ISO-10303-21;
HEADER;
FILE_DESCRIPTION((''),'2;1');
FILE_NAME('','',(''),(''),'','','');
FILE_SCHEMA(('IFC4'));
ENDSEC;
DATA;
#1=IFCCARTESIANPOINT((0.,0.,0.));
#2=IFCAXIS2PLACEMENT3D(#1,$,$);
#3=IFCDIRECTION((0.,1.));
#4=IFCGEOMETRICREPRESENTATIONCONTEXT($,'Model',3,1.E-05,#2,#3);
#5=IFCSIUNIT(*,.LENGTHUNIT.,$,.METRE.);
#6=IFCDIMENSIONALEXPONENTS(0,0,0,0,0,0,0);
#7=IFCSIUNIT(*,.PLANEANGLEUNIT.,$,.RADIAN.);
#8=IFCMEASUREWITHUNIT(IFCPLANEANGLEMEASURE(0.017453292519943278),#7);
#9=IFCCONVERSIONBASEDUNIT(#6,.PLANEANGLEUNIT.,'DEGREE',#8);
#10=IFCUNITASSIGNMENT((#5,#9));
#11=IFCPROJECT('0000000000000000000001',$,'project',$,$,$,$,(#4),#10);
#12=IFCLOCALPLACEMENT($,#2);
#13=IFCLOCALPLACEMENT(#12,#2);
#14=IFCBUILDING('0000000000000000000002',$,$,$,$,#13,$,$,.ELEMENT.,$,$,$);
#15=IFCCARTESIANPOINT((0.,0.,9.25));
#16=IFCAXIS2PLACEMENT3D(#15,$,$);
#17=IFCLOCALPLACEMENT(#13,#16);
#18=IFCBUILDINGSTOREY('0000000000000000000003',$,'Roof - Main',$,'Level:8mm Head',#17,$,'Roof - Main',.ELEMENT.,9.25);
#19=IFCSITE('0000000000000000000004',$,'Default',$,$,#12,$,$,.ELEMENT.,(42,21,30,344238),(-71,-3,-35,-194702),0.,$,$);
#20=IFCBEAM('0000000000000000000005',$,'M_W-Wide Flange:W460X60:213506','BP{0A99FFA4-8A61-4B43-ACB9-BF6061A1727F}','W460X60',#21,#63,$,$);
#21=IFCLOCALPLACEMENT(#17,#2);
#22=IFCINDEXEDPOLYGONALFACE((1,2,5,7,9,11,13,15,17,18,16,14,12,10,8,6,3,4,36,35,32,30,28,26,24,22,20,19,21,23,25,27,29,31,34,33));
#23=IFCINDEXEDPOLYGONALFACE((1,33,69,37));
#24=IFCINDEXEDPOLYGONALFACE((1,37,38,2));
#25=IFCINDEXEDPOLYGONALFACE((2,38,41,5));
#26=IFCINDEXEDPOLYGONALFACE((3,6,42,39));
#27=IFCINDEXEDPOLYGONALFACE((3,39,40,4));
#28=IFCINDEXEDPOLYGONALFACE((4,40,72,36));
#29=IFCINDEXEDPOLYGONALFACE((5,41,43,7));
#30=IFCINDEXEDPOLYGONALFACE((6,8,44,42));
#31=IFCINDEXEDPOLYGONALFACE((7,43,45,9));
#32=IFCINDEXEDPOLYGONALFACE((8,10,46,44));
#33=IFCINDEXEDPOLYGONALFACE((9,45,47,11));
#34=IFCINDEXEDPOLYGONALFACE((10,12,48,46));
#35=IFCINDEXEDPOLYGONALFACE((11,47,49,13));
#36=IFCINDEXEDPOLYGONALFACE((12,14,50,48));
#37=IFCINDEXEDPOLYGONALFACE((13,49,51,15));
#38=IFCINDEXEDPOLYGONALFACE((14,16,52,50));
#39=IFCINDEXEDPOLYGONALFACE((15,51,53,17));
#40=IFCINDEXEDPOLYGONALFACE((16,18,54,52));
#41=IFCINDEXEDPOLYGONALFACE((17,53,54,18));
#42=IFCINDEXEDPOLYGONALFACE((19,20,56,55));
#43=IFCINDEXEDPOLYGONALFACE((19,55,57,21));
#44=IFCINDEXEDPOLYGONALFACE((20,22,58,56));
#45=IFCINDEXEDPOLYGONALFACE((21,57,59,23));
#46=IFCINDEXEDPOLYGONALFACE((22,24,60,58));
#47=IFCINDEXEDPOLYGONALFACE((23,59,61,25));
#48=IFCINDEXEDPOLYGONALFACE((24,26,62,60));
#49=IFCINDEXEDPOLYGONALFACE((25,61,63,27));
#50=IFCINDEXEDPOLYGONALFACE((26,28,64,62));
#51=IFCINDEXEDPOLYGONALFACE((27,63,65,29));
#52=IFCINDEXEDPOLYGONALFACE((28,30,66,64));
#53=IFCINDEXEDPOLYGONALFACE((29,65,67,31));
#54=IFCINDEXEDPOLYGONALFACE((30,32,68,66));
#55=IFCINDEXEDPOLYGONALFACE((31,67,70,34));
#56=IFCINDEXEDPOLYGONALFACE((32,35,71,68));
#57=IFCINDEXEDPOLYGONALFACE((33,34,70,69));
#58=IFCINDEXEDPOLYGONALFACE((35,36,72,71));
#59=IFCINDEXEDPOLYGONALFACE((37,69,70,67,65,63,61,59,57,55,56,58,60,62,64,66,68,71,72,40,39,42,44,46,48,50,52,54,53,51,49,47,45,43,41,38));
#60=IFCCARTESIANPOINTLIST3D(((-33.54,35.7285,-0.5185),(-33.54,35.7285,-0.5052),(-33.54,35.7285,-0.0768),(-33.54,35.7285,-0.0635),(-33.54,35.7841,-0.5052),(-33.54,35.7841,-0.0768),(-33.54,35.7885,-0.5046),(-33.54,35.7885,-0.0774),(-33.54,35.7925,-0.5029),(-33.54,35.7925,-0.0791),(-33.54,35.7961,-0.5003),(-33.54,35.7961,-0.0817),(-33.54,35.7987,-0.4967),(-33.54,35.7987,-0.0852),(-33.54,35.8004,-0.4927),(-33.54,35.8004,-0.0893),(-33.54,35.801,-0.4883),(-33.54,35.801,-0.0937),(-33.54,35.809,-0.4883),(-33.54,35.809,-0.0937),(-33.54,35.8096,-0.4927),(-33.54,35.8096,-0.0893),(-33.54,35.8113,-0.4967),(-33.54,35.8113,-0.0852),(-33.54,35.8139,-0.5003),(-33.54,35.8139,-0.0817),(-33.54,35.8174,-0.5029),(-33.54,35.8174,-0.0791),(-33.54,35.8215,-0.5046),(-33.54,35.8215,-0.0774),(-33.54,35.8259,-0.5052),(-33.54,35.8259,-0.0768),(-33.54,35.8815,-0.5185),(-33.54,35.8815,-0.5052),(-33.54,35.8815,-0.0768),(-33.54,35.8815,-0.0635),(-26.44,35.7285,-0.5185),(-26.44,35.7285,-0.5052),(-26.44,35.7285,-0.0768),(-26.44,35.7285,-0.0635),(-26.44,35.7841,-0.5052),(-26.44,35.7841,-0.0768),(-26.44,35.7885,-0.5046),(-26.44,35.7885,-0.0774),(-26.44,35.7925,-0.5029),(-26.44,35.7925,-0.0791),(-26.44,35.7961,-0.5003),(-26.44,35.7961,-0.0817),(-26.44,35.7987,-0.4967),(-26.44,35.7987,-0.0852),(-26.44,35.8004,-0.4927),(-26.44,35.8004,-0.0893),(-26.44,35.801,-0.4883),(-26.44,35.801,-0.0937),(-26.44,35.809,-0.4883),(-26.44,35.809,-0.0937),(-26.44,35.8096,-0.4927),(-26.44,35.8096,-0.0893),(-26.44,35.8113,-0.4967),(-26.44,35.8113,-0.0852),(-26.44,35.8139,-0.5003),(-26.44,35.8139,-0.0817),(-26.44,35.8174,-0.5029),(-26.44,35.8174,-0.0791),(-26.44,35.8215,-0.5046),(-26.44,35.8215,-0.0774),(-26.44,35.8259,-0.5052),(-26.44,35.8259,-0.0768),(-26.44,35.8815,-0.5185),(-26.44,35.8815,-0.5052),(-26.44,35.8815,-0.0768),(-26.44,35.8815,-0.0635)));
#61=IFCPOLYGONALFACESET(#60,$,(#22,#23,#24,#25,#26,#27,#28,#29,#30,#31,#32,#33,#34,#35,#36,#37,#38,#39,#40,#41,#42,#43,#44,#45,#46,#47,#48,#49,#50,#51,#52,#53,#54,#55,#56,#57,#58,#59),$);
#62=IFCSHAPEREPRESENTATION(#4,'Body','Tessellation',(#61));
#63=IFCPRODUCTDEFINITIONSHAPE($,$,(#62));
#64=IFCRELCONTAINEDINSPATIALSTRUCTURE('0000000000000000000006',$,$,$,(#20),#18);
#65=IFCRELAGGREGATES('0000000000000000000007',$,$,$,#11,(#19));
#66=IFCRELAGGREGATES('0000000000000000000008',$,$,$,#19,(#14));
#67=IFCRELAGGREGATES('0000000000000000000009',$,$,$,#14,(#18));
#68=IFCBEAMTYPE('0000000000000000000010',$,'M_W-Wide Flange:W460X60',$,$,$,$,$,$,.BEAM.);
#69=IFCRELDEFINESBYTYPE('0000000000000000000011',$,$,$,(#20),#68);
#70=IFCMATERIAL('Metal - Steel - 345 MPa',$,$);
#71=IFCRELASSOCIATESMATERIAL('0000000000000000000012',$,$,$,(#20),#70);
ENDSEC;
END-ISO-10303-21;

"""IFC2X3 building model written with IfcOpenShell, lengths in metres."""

from ifc_helpers import new_model, entity, si_unit, converted_unit, direction, frame, origin, origin_2d, place, context, project, spatial, i_section, extrude, material, type_object, element, save


model = new_model("IFC2X3")

# Units and contexts
model_context = context("Model", 3, precision=1e-05, world=origin(), true_north=direction((0.0, 1.0)))
ifc_project = project(units=[si_unit("LENGTHUNIT", "METRE"), converted_unit("PLANEANGLEUNIT", "DEGREE", entity("IfcPlaneAngleMeasure", 0.017453292519943278), si_unit("PLANEANGLEUNIT", "RADIAN"), dimensions=[0, 0, 0, 0, 0, 0, 0])], contexts=[model_context])

# Site, building, storey
site_placement = place(None, origin())
site = spatial("IfcSite", under=ifc_project, at=site_placement, Name="Default", CompositionType="ELEMENT", RefLatitude=(42, 21, 30, 344238), RefLongitude=(-71, -3, -35, -194702), RefElevation=0.0)
building_placement = place(site_placement, origin())
building = spatial("IfcBuilding", under=site, at=building_placement, CompositionType="ELEMENT")
storey_placement = place(building_placement, frame((0.0, 0.0, 9.25)))
storey = spatial("IfcBuildingStorey", under=building, at=storey_placement, Name="Roof - Main", ObjectType="Level:8mm Head", LongName="Roof - Main", CompositionType="ELEMENT", Elevation=9.25)

# Shared definitions
ifc_material_1 = material(Name="Metal - Steel - 345 MPa")

# Beam
beam_type_1 = type_object("IfcBeamType", Name="M_W-Wide Flange:W460X60", PredefinedType="BEAM")
beam_1_placement = place(storey_placement, frame((-26.44, 35.805, -0.291), z_axis=(1.0, 0.0, 0.0), x_axis=(0.0, 1.0, 0.0)))
element("IfcBeam", 1, at=beam_1_placement, inside=storey, type_object=beam_type_1, material=ifc_material_1, Name="M_W-Wide Flange:W460X60:213506", Description="BP{0A99FFA4-8A61-4B43-ACB9-BF6061A1727F}", ObjectType="W460X60", context=model_context, shape_type="SweptSolid", body=[
    extrude(i_section(OverallWidth=0.153, OverallDepth=0.455, WebThickness=0.008, FlangeThickness=0.0133, FilletRadius=0.0169, at=origin_2d()), origin(), (0.0, 0.0, -1.0), 7.1),
])

save(model, "model.ifc")
